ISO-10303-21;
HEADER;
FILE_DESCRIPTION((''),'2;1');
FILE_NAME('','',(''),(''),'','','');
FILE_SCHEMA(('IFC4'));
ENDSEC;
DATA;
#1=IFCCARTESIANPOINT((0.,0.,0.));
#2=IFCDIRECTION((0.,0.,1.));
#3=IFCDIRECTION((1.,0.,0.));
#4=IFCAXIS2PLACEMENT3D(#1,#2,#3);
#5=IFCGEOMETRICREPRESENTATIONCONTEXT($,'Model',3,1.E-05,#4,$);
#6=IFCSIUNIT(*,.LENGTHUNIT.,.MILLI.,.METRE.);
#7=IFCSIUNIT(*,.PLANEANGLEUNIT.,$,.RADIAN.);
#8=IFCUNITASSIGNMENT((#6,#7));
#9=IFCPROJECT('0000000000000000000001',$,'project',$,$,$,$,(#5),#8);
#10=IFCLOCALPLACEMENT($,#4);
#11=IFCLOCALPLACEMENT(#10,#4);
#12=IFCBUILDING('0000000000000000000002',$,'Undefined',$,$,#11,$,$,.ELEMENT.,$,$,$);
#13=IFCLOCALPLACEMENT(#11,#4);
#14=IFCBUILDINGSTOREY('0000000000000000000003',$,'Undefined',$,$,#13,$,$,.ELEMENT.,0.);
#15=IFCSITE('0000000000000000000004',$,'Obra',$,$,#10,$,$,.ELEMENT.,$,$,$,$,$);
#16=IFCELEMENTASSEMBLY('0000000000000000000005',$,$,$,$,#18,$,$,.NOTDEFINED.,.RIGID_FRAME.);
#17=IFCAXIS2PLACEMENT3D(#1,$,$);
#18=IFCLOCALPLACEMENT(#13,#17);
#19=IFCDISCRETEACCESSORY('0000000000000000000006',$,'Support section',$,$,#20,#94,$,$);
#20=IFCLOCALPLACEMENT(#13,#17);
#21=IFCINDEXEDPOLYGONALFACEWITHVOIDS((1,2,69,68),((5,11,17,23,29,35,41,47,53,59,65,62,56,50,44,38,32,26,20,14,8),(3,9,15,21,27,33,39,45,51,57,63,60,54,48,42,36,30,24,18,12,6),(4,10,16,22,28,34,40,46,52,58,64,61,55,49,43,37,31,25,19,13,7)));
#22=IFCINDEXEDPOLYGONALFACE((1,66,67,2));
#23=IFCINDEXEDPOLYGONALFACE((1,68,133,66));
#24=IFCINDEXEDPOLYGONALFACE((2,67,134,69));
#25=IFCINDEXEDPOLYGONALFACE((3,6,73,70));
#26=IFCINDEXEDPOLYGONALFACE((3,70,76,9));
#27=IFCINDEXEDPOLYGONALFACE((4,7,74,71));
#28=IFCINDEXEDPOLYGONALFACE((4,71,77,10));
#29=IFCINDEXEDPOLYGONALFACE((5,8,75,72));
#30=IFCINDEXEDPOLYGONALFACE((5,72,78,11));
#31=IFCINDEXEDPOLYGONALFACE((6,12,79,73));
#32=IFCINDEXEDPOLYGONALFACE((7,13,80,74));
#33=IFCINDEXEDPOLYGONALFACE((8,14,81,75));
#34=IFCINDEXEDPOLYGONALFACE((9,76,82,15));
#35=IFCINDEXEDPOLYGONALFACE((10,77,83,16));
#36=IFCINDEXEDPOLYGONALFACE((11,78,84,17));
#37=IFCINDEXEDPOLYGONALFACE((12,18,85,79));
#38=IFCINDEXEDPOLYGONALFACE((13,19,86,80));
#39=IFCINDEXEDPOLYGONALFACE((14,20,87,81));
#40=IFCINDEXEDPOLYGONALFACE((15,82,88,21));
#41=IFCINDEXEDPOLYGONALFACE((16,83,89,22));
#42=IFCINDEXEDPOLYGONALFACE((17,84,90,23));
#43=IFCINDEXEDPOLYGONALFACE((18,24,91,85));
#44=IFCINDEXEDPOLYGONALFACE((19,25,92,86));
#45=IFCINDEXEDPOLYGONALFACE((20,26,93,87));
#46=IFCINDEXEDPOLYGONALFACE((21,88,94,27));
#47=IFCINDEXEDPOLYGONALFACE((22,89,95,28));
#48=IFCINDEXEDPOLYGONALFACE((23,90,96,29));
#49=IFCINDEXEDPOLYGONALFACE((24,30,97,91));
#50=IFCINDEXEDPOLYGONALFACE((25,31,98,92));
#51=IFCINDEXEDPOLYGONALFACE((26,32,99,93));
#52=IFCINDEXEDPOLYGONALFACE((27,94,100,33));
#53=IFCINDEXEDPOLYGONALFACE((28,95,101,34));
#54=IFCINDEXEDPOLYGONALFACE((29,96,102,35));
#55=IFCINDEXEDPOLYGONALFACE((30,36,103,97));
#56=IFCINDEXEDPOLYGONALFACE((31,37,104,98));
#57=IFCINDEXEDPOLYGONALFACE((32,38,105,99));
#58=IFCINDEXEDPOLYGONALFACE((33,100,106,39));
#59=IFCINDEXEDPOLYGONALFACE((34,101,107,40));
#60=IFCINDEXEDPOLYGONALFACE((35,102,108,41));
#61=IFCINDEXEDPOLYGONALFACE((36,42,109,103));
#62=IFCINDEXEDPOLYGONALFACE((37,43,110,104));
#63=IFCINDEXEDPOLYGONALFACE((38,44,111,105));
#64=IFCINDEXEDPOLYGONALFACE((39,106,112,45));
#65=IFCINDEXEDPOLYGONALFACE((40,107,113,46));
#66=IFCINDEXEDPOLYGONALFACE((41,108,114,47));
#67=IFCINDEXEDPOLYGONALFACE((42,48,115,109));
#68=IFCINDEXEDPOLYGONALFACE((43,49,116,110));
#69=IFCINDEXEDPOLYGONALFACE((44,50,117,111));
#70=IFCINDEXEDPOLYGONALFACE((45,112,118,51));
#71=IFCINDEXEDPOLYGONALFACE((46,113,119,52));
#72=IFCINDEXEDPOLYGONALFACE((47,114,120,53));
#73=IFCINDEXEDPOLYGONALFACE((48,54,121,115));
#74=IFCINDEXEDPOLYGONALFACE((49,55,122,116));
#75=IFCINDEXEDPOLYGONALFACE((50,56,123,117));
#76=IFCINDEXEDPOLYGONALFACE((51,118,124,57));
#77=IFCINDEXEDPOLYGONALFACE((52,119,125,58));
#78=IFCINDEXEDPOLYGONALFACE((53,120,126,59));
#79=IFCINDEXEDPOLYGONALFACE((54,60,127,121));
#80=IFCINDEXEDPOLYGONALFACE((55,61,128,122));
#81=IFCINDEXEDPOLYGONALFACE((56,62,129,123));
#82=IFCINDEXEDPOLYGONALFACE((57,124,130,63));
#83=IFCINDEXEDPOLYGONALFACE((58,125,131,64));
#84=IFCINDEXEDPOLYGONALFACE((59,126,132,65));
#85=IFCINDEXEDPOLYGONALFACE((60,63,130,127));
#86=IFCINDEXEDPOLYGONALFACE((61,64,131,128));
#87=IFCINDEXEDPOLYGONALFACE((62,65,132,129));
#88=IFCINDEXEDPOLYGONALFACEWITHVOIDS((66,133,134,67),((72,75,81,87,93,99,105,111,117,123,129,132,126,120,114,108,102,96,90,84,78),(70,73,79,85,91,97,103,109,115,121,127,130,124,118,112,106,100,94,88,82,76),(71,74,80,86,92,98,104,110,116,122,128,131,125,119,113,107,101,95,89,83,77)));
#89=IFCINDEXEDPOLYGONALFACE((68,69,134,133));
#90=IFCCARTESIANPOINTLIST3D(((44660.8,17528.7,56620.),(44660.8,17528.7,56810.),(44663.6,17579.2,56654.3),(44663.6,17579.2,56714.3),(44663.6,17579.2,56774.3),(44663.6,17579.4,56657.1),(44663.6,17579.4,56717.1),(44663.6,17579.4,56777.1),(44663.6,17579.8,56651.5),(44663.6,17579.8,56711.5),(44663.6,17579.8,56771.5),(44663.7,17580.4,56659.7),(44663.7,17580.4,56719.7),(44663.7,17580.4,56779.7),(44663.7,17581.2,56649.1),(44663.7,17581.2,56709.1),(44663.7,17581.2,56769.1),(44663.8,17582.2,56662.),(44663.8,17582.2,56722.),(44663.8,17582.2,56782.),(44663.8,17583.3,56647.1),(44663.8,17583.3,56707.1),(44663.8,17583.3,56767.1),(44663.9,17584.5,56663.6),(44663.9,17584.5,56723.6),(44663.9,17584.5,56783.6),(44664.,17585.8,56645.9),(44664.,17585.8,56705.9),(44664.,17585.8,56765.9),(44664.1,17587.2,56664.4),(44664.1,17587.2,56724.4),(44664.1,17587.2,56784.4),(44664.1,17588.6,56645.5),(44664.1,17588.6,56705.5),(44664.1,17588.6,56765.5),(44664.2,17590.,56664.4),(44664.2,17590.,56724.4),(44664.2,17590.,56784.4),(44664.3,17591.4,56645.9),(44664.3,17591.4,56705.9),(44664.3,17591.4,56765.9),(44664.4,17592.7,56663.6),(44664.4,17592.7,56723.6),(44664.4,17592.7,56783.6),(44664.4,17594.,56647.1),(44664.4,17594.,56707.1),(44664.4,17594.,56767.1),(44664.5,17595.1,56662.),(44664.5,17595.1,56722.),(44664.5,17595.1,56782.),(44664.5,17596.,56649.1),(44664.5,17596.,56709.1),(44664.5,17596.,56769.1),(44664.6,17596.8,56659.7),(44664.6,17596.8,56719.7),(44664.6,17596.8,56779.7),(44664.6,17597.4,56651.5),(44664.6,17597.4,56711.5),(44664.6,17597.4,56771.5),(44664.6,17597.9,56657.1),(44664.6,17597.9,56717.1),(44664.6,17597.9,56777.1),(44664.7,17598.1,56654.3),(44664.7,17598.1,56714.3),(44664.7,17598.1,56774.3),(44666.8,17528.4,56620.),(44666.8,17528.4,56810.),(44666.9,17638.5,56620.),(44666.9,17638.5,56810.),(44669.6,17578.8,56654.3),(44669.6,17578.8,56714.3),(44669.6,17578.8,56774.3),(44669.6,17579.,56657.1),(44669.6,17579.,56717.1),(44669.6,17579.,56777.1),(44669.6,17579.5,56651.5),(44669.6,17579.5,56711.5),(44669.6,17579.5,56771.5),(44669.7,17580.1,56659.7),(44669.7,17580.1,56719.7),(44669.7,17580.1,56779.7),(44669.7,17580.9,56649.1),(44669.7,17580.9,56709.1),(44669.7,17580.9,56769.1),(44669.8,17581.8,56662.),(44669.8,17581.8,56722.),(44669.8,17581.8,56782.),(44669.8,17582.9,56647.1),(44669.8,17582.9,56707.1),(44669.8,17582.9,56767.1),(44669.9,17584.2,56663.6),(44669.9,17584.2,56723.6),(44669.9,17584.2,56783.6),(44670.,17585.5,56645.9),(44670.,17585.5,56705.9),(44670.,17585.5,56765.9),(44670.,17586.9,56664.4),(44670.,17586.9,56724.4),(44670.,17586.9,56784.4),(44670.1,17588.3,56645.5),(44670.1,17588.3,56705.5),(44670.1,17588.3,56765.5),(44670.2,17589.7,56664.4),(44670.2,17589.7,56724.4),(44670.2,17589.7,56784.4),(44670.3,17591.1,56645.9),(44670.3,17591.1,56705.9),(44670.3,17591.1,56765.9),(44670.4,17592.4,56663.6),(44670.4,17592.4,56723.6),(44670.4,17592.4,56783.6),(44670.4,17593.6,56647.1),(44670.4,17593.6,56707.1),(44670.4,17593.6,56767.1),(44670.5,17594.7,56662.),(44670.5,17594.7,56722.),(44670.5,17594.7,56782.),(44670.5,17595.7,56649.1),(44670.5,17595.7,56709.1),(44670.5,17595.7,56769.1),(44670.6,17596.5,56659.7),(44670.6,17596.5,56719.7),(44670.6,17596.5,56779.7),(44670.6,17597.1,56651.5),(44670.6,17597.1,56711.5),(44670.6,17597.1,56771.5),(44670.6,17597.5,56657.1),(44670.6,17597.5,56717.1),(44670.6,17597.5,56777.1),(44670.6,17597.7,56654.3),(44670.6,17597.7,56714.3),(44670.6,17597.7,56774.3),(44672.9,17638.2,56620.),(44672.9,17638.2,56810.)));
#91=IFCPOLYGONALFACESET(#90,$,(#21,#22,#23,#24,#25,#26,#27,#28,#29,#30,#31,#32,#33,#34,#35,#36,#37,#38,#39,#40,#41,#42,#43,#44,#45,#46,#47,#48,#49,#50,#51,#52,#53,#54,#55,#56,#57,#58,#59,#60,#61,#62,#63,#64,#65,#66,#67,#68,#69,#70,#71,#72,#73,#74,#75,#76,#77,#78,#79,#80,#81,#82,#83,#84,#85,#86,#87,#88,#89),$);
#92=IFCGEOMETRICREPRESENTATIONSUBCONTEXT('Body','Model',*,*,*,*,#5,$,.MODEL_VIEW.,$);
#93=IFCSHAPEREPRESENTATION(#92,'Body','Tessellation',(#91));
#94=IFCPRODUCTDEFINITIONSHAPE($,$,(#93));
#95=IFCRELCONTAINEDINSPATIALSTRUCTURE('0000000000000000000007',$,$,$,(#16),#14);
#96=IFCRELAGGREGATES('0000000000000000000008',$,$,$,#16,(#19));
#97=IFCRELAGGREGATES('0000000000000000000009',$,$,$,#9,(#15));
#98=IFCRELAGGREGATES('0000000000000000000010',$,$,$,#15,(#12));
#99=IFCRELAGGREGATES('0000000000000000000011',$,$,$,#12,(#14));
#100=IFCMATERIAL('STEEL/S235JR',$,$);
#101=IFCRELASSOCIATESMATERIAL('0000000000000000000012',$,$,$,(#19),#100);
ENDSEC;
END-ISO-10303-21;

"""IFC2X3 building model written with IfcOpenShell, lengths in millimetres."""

from ifc_helpers import new_model, si_unit, frame, origin_with_axes, origin_2d_with_axis, place, context, subcontext, project, spatial, rectangle, circle, extrude, source, transform, mapped, material, element, aggregate, save


model = new_model("IFC2X3")

# Units and contexts
model_context = context("Model", 3, precision=1e-05, world=origin_with_axes())
body_context = subcontext(model_context, "Body", "Model", "MODEL_VIEW")
ifc_project = project(units=[si_unit("LENGTHUNIT", "METRE", prefix="MILLI"), si_unit("PLANEANGLEUNIT", "RADIAN")], contexts=[model_context])

# Site, building, storey
site_placement = place(None, origin_with_axes())
site = spatial("IfcSite", under=ifc_project, at=site_placement, Name="Obra", CompositionType="ELEMENT")
building_placement = place(site_placement, origin_with_axes())
building = spatial("IfcBuilding", under=site, at=building_placement, Name="Undefined", CompositionType="ELEMENT")
storey_placement = place(building_placement, origin_with_axes())
storey = spatial("IfcBuildingStorey", under=building, at=storey_placement, Name="Undefined", CompositionType="ELEMENT", Elevation=0.0)

# Element assembly
ifc_material_1 = material(Name="STEEL/S235JR")
assembly_1_placement = place(storey_placement, origin_with_axes())
assembly_1 = element("IfcElementAssembly", 1, at=assembly_1_placement, inside=storey, AssemblyPlace="NOTDEFINED", PredefinedType="RIGID_FRAME")

# Discrete accessory, opening
shared_shape_1 = source(origin_with_axes(), body_context, "Body", "SweptSolid", [
    extrude(circle(Radius=9.5, at=origin_2d_with_axis()), frame((0.0, -9.2, 0.0), z_axis=(0.0, 1.0, 0.0), x_axis=(1.0, 0.0, 0.0)), (0.0, 0.0, 1.0), 6.2),
])
discrete_accessory_1_placement = place(assembly_1_placement, frame((44666.9, 17583.5, 56620.0), z_axis=(0.0, 0.0, 1.0), x_axis=(-0.055268, -0.998472, 0.0)))
discrete_accessory_1 = element("IfcDiscreteAccessory", 2, at=discrete_accessory_1_placement, material=ifc_material_1, Name="Support section", context=body_context, shape_type="SweptSolid", body=[
    extrude(rectangle(XDim=6.0, YDim=110.0, at=origin_2d_with_axis()), frame((0.0, 0.0, 190.0), z_axis=(0.0, 0.0, -1.0), x_axis=(0.0, 1.0, 0.0)), (0.0, 0.0, 1.0), 190.0),
])
opening_1_placement = place(assembly_1_placement, frame((44658.3, 17538.9, 56835.0), z_axis=(0.055268, 0.998472, 0.0), x_axis=(0.0, 0.0, -1.0)))
element("IfcOpeningElement", 3, at=opening_1_placement, cuts=discrete_accessory_1, ObjectType="Opening", context=body_context, shape_type="MappedRepresentation", body=[
    mapped(shared_shape_1, transform((60.0, 0.0, 50.0))),
    mapped(shared_shape_1, transform((120.0, 0.0, 50.0))),
    mapped(shared_shape_1, transform((180.0, 0.0, 50.0))),
])
aggregate(assembly_1, [discrete_accessory_1])

save(model, "model.ifc")
